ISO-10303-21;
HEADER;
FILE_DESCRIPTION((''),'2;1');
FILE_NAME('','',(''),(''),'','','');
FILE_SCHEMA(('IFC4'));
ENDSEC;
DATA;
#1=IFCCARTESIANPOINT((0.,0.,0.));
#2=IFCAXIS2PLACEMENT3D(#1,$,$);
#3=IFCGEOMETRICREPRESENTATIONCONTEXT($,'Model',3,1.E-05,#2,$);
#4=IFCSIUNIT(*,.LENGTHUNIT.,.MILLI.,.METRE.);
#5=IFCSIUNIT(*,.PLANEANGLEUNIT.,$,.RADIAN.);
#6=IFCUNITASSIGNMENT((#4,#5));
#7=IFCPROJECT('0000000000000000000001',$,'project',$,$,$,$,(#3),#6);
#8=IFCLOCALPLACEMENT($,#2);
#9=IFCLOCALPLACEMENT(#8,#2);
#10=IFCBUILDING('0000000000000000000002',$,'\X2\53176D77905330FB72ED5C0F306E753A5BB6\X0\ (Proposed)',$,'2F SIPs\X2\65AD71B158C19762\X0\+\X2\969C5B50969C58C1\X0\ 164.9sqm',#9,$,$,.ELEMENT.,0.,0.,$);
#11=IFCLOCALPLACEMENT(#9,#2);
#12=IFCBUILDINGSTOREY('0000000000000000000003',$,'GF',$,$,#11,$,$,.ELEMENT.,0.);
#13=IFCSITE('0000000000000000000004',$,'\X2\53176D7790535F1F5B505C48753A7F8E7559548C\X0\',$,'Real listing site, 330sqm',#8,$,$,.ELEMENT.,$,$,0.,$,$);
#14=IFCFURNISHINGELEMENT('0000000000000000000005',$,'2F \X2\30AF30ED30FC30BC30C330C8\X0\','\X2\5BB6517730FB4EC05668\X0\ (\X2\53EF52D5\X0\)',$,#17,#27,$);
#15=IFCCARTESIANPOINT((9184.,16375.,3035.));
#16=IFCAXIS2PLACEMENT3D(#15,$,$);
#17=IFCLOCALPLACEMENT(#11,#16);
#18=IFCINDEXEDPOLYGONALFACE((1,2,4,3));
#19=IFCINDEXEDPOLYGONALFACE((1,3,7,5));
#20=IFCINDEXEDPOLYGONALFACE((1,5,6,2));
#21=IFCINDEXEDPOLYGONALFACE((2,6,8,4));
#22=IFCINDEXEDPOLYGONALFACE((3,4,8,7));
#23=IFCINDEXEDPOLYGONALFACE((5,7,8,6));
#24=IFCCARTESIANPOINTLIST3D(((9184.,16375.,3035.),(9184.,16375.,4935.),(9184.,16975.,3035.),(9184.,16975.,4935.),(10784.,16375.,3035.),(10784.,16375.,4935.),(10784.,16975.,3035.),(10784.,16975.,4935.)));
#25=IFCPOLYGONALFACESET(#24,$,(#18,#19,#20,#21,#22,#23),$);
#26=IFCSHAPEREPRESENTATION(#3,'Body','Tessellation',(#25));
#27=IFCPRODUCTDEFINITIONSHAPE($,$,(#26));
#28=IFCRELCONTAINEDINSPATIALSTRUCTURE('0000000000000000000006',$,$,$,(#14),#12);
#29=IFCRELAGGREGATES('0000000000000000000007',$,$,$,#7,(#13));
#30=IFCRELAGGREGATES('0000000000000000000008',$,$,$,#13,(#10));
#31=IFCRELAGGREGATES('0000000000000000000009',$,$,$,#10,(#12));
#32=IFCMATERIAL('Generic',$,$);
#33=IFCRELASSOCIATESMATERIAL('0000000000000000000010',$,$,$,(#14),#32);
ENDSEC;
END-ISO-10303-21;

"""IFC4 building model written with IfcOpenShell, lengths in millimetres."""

from ifc_helpers import new_model, si_unit, frame, frame_2d, origin, place, context, project, spatial, rectangle, extrude, material, element, save


model = new_model("IFC4")

# Units and contexts
model_context = context("Model", 3, precision=1e-05, world=origin())
ifc_project = project(units=[si_unit("LENGTHUNIT", "METRE", prefix="MILLI"), si_unit("PLANEANGLEUNIT", "RADIAN")], contexts=[model_context])

# Site, building, storey
site_placement = place(None, origin())
site = spatial("IfcSite", under=ifc_project, at=site_placement, Name="北海道弟子屈町美留和", ObjectType="Real listing site, 330sqm", CompositionType="ELEMENT", RefElevation=0.0)
building_placement = place(site_placement, origin())
building = spatial("IfcBuilding", under=site, at=building_placement, Name="北海道・狭小の町家 (Proposed)", ObjectType="2F SIPs断熱壁面+障子障壁 164.9sqm", CompositionType="ELEMENT", ElevationOfRefHeight=0.0, ElevationOfTerrain=0.0)
storey_placement = place(building_placement, origin())
storey = spatial("IfcBuildingStorey", under=building, at=storey_placement, Name="GF", CompositionType="ELEMENT", Elevation=0.0)

# Shared definitions
ifc_material_1 = material(Name="Generic")

# Furnishing element
furnishing_1_placement = place(storey_placement, frame((9184.0, 16375.0, 3035.0)))
element("IfcFurnishingElement", 1, at=furnishing_1_placement, inside=storey, material=ifc_material_1, Name="2F クローゼット", Description="家具・什器 (可動)", context=model_context, shape_type="SweptSolid", body=[
    extrude(rectangle(XDim=1600.0, YDim=600.0, at=frame_2d((800.0, 300.0))), frame((9184.0, 16375.0, 3035.0)), (0.0, 0.0, 1.0), 1900.0),
])

save(model, "model.ifc")
